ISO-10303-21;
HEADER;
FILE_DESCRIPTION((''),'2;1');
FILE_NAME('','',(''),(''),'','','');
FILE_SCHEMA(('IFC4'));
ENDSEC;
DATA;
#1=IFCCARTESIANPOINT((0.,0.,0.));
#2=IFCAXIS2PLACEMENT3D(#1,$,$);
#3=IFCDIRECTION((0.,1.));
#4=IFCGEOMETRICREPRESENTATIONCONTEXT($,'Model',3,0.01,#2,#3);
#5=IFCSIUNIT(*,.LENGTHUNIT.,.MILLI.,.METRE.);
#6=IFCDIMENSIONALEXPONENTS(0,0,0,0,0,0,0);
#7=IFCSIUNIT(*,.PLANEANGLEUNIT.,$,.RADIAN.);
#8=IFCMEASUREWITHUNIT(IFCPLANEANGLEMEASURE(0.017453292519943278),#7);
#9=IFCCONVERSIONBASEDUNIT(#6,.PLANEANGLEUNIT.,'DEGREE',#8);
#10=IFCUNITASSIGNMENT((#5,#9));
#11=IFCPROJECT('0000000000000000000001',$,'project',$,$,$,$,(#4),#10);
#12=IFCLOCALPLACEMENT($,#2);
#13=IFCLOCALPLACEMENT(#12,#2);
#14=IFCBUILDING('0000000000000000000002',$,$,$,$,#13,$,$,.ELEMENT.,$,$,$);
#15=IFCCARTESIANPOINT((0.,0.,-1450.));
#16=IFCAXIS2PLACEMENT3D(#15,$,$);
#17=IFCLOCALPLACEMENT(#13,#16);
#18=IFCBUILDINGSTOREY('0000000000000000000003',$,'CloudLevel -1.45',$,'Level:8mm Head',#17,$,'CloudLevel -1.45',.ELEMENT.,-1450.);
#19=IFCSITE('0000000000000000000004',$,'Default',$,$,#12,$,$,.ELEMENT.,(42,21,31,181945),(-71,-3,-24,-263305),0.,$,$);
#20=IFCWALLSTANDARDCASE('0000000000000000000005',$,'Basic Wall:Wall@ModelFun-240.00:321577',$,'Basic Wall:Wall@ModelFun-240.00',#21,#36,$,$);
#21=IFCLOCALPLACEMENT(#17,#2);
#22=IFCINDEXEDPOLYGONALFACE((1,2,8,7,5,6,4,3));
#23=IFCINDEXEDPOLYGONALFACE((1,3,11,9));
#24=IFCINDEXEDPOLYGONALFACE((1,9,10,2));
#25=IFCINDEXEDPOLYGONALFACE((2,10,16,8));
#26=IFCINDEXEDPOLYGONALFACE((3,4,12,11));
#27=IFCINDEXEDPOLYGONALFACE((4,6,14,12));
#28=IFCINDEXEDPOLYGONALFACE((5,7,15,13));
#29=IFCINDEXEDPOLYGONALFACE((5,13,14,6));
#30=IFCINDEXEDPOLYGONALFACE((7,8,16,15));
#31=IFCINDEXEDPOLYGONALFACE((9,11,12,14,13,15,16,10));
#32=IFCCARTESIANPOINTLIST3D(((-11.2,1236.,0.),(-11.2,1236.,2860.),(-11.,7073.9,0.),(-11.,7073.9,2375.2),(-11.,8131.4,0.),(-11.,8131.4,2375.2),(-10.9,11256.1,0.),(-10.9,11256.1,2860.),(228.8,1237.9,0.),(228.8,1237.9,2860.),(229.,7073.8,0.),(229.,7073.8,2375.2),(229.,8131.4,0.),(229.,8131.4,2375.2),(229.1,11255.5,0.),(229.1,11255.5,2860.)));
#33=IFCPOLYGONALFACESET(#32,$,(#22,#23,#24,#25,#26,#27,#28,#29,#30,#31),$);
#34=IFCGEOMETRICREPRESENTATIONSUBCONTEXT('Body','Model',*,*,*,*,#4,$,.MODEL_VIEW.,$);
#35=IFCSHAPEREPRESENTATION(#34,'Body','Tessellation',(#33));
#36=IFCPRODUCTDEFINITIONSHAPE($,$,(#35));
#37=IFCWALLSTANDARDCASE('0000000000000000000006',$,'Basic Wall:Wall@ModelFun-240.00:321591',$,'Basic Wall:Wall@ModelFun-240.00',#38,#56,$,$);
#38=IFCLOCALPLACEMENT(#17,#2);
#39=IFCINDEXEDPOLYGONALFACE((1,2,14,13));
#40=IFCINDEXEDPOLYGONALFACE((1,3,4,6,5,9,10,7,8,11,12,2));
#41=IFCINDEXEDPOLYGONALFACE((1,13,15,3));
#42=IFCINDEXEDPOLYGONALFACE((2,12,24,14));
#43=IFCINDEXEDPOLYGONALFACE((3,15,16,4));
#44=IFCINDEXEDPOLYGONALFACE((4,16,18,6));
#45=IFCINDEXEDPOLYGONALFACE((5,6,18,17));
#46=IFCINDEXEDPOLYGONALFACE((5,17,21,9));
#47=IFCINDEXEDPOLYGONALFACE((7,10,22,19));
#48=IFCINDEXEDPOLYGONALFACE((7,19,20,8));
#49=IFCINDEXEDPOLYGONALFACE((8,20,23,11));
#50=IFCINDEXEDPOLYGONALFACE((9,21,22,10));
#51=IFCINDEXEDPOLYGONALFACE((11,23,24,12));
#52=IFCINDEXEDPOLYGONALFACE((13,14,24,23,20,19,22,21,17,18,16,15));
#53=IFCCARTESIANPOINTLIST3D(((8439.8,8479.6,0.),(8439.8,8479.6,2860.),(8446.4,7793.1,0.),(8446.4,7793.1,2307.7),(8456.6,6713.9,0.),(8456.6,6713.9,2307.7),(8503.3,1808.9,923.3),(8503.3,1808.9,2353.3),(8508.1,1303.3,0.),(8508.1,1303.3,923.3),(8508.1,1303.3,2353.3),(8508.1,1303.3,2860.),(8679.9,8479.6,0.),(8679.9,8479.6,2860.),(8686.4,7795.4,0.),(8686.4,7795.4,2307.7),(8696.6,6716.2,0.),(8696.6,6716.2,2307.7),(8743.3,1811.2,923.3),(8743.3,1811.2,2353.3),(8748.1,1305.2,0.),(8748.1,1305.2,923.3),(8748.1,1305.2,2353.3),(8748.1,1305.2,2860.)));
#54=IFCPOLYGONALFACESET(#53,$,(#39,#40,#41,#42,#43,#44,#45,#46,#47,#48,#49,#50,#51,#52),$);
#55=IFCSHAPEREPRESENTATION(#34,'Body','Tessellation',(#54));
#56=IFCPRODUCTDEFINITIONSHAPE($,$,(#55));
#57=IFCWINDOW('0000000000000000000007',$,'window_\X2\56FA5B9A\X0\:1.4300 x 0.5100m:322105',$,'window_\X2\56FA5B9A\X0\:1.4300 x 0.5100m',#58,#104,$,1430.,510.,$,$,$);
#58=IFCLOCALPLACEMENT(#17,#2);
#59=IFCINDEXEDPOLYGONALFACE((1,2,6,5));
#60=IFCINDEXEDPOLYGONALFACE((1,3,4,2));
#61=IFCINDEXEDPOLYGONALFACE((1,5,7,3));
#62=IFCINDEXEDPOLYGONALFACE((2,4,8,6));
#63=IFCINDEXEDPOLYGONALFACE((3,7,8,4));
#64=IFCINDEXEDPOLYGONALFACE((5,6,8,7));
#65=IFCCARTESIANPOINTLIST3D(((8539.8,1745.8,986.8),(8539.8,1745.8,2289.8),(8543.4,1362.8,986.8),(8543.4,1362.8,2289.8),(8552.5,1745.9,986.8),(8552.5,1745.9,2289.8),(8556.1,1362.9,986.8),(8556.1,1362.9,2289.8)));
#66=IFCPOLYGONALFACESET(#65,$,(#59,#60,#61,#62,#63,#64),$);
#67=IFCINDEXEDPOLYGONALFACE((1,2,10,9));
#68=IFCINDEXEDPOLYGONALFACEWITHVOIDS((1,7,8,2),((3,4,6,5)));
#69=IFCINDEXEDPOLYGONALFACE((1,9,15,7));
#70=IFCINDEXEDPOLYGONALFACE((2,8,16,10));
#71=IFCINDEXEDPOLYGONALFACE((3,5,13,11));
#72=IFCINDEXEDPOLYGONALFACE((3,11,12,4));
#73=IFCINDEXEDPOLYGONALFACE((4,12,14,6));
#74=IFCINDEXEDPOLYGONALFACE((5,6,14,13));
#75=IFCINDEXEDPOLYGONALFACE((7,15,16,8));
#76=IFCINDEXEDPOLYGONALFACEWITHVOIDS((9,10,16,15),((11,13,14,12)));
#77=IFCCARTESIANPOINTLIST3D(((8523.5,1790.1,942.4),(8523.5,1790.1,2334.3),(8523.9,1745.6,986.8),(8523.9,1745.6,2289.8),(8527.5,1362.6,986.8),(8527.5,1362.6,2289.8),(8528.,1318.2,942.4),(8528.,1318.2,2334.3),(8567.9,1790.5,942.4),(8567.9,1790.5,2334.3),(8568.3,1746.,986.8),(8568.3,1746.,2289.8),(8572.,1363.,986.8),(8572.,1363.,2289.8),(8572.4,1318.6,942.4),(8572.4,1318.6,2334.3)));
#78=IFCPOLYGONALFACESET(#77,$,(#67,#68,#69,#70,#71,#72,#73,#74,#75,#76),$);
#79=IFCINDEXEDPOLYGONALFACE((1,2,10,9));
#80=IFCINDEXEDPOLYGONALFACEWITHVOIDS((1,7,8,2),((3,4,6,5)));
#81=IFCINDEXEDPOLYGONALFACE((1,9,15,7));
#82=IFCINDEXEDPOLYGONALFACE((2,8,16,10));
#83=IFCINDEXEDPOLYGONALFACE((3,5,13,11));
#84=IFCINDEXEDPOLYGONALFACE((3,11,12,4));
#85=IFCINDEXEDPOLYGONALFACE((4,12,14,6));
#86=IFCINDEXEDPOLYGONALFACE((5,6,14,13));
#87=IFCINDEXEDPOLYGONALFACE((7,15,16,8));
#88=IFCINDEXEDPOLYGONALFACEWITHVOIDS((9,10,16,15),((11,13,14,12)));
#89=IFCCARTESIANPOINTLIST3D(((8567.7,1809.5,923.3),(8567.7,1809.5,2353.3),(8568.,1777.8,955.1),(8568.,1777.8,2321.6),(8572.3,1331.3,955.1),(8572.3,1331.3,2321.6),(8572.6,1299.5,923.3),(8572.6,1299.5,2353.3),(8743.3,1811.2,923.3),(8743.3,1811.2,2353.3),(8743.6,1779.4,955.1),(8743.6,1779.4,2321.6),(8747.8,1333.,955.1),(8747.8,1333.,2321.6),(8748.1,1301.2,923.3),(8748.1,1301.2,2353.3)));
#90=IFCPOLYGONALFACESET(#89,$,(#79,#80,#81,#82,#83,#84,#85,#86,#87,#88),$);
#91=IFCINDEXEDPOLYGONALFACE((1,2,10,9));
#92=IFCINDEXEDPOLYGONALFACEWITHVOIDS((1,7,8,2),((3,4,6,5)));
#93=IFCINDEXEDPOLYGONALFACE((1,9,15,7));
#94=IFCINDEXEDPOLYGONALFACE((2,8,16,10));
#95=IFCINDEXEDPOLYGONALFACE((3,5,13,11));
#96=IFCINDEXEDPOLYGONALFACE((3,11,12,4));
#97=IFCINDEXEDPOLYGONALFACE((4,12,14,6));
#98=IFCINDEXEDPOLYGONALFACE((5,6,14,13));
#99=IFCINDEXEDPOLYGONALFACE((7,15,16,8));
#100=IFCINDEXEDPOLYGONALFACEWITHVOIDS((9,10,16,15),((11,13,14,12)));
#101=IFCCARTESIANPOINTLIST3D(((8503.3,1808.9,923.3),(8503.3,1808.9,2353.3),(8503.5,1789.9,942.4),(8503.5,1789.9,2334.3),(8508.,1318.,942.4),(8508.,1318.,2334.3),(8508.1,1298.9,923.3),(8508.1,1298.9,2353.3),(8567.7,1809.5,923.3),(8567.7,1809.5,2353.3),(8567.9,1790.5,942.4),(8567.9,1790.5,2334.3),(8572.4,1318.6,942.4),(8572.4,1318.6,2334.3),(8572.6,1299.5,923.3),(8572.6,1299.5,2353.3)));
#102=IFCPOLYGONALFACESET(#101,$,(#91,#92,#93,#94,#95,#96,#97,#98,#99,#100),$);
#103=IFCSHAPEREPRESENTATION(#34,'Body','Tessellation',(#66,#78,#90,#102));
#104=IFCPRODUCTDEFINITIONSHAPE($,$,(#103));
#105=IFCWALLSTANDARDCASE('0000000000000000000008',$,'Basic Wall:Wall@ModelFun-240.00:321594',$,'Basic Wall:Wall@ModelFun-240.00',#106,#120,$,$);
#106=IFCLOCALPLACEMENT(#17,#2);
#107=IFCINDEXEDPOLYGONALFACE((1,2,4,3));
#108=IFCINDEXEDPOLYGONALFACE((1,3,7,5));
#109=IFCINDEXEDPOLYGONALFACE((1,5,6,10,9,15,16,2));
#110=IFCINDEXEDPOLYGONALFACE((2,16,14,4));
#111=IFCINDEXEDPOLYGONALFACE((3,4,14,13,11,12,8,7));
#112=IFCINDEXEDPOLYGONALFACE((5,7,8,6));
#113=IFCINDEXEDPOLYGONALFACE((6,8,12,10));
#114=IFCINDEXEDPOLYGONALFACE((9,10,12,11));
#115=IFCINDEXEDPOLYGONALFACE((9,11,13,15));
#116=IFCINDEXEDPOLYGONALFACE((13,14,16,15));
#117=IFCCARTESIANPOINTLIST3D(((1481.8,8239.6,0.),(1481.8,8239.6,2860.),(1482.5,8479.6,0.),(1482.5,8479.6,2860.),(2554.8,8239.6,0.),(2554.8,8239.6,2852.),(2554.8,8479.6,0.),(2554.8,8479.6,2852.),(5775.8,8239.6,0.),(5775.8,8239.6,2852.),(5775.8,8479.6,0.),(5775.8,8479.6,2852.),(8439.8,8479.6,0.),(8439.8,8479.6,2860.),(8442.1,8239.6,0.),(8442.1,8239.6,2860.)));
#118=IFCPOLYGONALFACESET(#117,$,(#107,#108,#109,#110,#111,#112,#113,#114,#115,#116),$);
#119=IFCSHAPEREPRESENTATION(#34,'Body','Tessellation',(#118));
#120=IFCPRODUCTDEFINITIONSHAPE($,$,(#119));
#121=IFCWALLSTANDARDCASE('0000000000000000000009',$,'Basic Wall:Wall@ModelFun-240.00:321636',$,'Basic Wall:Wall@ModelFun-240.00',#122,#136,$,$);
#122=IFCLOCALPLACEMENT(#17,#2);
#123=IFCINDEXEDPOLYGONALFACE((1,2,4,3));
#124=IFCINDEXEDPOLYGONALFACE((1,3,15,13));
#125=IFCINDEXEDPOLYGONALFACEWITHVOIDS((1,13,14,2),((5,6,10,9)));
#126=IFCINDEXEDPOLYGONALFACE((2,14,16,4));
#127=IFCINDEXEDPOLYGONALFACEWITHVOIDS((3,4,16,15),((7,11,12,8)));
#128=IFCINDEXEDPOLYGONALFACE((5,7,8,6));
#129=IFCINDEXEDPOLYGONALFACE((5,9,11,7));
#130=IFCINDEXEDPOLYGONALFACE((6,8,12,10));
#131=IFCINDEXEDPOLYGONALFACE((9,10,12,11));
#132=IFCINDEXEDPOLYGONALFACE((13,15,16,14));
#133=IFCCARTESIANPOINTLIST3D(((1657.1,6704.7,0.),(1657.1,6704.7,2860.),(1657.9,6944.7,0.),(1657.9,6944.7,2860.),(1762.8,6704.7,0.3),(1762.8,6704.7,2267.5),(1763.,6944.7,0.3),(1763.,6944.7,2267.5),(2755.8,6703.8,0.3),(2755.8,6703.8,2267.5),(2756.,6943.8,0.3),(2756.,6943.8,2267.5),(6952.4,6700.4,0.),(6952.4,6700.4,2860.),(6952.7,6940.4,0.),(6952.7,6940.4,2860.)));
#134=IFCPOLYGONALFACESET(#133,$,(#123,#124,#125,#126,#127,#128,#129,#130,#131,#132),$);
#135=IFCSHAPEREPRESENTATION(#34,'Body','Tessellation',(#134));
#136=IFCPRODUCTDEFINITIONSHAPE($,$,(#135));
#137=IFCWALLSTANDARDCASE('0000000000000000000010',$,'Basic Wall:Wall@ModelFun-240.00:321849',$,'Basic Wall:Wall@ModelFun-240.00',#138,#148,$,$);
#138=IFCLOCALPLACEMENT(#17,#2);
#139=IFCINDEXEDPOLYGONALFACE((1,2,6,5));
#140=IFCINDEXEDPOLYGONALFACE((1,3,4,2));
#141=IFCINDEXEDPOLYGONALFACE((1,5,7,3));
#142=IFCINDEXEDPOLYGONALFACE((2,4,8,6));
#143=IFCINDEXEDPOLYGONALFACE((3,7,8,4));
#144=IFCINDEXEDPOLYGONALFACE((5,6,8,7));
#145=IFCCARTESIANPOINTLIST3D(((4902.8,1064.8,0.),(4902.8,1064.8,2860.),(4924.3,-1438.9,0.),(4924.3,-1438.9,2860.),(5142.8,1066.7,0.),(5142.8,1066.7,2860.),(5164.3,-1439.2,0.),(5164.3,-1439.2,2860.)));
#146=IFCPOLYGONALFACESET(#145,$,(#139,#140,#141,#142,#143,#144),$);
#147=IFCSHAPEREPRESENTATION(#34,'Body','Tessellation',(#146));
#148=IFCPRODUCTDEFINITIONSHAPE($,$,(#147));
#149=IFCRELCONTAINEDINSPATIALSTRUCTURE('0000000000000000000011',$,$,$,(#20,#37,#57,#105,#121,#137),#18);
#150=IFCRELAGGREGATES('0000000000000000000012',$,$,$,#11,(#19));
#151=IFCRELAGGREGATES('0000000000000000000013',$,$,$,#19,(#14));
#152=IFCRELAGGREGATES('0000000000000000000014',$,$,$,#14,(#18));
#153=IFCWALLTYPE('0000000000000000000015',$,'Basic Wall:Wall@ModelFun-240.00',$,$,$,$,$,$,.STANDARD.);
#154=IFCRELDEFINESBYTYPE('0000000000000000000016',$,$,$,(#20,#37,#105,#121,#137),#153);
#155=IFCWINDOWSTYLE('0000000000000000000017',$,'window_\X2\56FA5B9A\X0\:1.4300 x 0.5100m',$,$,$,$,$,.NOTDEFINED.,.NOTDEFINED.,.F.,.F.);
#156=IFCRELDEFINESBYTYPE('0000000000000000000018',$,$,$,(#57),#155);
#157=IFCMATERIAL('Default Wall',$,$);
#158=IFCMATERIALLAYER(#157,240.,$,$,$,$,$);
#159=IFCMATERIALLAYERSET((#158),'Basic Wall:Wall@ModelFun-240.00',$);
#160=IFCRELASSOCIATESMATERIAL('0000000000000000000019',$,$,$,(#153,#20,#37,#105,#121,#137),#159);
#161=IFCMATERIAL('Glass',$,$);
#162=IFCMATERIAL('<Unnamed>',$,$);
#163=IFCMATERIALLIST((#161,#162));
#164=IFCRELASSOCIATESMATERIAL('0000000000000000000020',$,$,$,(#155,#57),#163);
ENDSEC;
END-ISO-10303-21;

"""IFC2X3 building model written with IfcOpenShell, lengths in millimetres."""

from ifc_helpers import new_model, entity, si_unit, converted_unit, direction, frame, frame_2d, origin, place, context, subcontext, project, spatial, polyline, rectangle, outline, extrude, source, transform, mapped, material, material_list, layer, layer_set, layer_usage, type_object, type_shapes, element, fill, save


model = new_model("IFC2X3")

# Units and contexts
model_context = context("Model", 3, precision=0.01, world=origin(), true_north=direction((0.0, 1.0)))
body_context = subcontext(model_context, "Body", "Model", "MODEL_VIEW")
ifc_project = project(units=[si_unit("LENGTHUNIT", "METRE", prefix="MILLI"), converted_unit("PLANEANGLEUNIT", "DEGREE", entity("IfcPlaneAngleMeasure", 0.017453292519943278), si_unit("PLANEANGLEUNIT", "RADIAN"), dimensions=[0, 0, 0, 0, 0, 0, 0])], contexts=[model_context])

# Site, building, storey
site_placement = place(None, origin())
site = spatial("IfcSite", under=ifc_project, at=site_placement, Name="Default", CompositionType="ELEMENT", RefLatitude=(42, 21, 31, 181945), RefLongitude=(-71, -3, -24, -263305), RefElevation=0.0)
building_placement = place(site_placement, origin())
building = spatial("IfcBuilding", under=site, at=building_placement, CompositionType="ELEMENT")
storey_placement = place(building_placement, frame((0.0, 0.0, -1450.0)))
storey = spatial("IfcBuildingStorey", under=building, at=storey_placement, Name="CloudLevel -1.45", ObjectType="Level:8mm Head", LongName="CloudLevel -1.45", CompositionType="ELEMENT", Elevation=-1450.0)

# Shared definitions
ifc_material_1 = material(Name="Default Wall")
ifc_layer_1 = layer(ifc_material_1, 240.0)
ifc_layer_set_1 = layer_set([ifc_layer_1], Name="Basic Wall:Wall@ModelFun-240.00")
ifc_layer_usage_1 = layer_usage(ifc_layer_set_1, "AXIS2", "NEGATIVE", 120.0)
wall_type_1 = type_object("IfcWallType", Name="Basic Wall:Wall@ModelFun-240.00", PredefinedType="STANDARD", material=ifc_layer_set_1)
ifc_material_2 = material(Name="Glass")
ifc_material_3 = material(Name="<Unnamed>")
ifc_material_list = material_list([ifc_material_2, ifc_material_3])

# Wall, opening
wall_1_placement = place(storey_placement, frame((109.1, 11256.1, 0.0), z_axis=(0.0, 0.0, 1.0), x_axis=(-0.000035, -1.0, 0.0)))
wall_1 = element("IfcWallStandardCase", 1, at=wall_1_placement, inside=storey, type_object=wall_type_1, material=ifc_layer_usage_1, Name="Basic Wall:Wall@ModelFun-240.00:321577", ObjectType="Basic Wall:Wall@ModelFun-240.00", context=body_context, shape_type="SweptSolid", body=[
    extrude(outline(polyline([(0.0, -120.0), (2902.8, -120.0), (3022.8, -120.0), (4539.7, -120.0), (4739.7, -120.0), (8178.4, -120.0), (8418.4, -120.0), (10020.2, -120.0), (10018.3, 120.0), (3012.2, 120.0), (2772.2, 120.0), (0.6, 120.0), (0.0, -120.0)])), origin(), (0.0, 0.0, 1.0), 2860.0),
])
opening_1_placement = place(wall_1_placement, frame((3124.8, -120.0, 0.0)))
element("IfcOpeningElement", 2, at=opening_1_placement, cuts=wall_1, ObjectType="Opening", context=body_context, shape_type="SweptSolid", body=[
    extrude(rectangle(XDim=1057.5, YDim=2375.2, at=frame_2d((1187.6, 528.8), x_axis=(0.0, 1.0))), frame((0.0, 0.0, 0.0), z_axis=(0.0, 1.0, 0.0), x_axis=(0.0, 0.0, 1.0)), (0.0, 0.0, 1.0), 240.0),
])

# Wall, openings, window
wall_2_placement = place(storey_placement, frame((8559.8, 8480.7, 0.0), z_axis=(0.0, 0.0, 1.0), x_axis=(0.009512, -0.999955, 0.0)))
wall_2 = element("IfcWallStandardCase", 3, at=wall_2_placement, inside=storey, type_object=wall_type_1, material=ifc_layer_usage_1, Name="Basic Wall:Wall@ModelFun-240.00:321591", ObjectType="Basic Wall:Wall@ModelFun-240.00", context=body_context, shape_type="SweptSolid", body=[
    extrude(outline(polyline([(0.0, -120.0), (240.0, -120.0), (5749.5, -120.0), (5989.6, -120.0), (7176.6, -120.0), (7177.0, 120.0), (2.3, 120.0), (0.0, -120.0)])), origin(), (0.0, 0.0, 1.0), 2860.0),
])
opening_2_placement = place(wall_2_placement, frame((686.5, -120.0, -6.7)))
element("IfcOpeningElement", 4, at=opening_2_placement, cuts=wall_2, ObjectType="Opening", context=body_context, shape_type="SweptSolid", body=[
    extrude(rectangle(XDim=1079.2, YDim=2314.4, at=frame_2d((1157.2, 539.6), x_axis=(0.0, 1.0))), frame((0.0, 0.0, 0.0), z_axis=(0.0, 1.0, 0.0), x_axis=(0.0, 0.0, 1.0)), (0.0, 0.0, 1.0), 240.0),
])
opening_3_placement = place(wall_2_placement, frame((7181.0, 120.0, 923.3)))
opening_3 = element("IfcOpeningElement", 5, at=opening_3_placement, cuts=wall_2, ObjectType="Opening", context=body_context, shape_type="SweptSolid", body=[
    extrude(rectangle(XDim=1430.0, YDim=510.0, at=frame_2d((715.0, 255.0), x_axis=(-1.0, 0.0))), frame((0.0, 0.0, 0.0), z_axis=(0.0, -1.0, 0.0), x_axis=(0.0, 0.0, 1.0)), (0.0, 0.0, 1.0), 240.0),
])
window_style_1 = type_object("IfcWindowStyle", Name="window_固定:1.4300 x 0.5100m", ConstructionType="NOTDEFINED", OperationType="NOTDEFINED", ParameterTakesPrecedence=False, Sizeable=False, material=ifc_material_list)
shared_shape_1 = source(origin(), body_context, "Body", "SweptSolid", [
    extrude(rectangle(XDim=383.0, YDim=12.7, at=frame_2d((0.0, 0.0), x_axis=(1.0, 0.0))), frame((331.2, 197.8, 63.5)), (0.0, 0.0, 1.0), 1303.0),
    extrude(outline(polyline([(-235.9, -695.9), (235.9, -695.9), (235.9, 695.9), (-235.9, 695.9), (-235.9, -695.9)]), holes=[polyline([(-191.5, -651.5), (-191.5, 651.5), (191.5, 651.5), (191.5, -651.5), (-191.5, -651.5)])]), frame((331.2, 220.0, 715.0), z_axis=(0.0, -1.0, 0.0), x_axis=(-1.0, 0.0, 0.0)), (0.0, 0.0, 1.0), 44.4),
    extrude(outline(polyline([(-255.0, -715.0), (255.0, -715.0), (255.0, 715.0), (-255.0, 715.0), (-255.0, -715.0)]), holes=[polyline([(-223.2, -683.2), (-223.2, 683.2), (223.2, 683.2), (223.2, -683.2), (-223.2, -683.2)])]), frame((331.2, 175.5, 715.0), z_axis=(0.0, -1.0, 0.0), x_axis=(-1.0, 0.0, 0.0)), (0.0, 0.0, 1.0), 175.5),
    extrude(outline(polyline([(-715.0, -255.0), (715.0, -255.0), (715.0, 255.0), (-715.0, 255.0), (-715.0, -255.0)]), holes=[polyline([(-695.9, -235.9), (-695.9, 235.9), (695.9, 235.9), (695.9, -235.9), (-695.9, -235.9)])]), frame((331.2, 240.0, 715.0), z_axis=(0.0, -1.0, 0.0), x_axis=(0.0, 0.0, -1.0)), (0.0, 0.0, 1.0), 64.4),
])
type_shapes(window_style_1, [shared_shape_1])
window_1_placement = place(opening_3_placement, frame((76.2, 0.0, 0.0), z_axis=(0.0, 0.0, 1.0), x_axis=(-1.0, 0.0, 0.0)))
window_1 = element("IfcWindow", 6, at=window_1_placement, inside=storey, type_object=window_style_1, material=ifc_material_list, Name="window_固定:1.4300 x 0.5100m:322105", ObjectType="window_固定:1.4300 x 0.5100m", OverallHeight=1430.0, OverallWidth=510.0, context=body_context, shape_type="MappedRepresentation", body=[
    mapped(shared_shape_1, transform((0.0, 0.0, 0.0), scale=1.0)),
])
fill(opening_3, window_1)

# Wall, opening
wall_3_placement = place(storey_placement, frame((8442.1, 8359.6, 0.0), z_axis=(0.0, 0.0, 1.0), x_axis=(-1.0, 0.0, 0.0)))
wall_3 = element("IfcWallStandardCase", 7, at=wall_3_placement, inside=storey, type_object=wall_type_1, material=ifc_layer_usage_1, Name="Basic Wall:Wall@ModelFun-240.00:321594", ObjectType="Basic Wall:Wall@ModelFun-240.00", context=body_context, shape_type="SweptSolid", body=[
    extrude(outline(polyline([(2.3, -120.0), (6871.1, -120.0), (6959.6, -120.0), (6960.3, 101.5), (6960.4, 120.0), (6780.4, 120.0), (0.0, 120.0), (2.3, -120.0)])), origin(), (0.0, 0.0, 1.0), 2860.0),
])
opening_4_placement = place(wall_3_placement, frame((2666.3, -120.0, 0.0)))
element("IfcOpeningElement", 8, at=opening_4_placement, cuts=wall_3, ObjectType="Opening", context=body_context, shape_type="SweptSolid", body=[
    extrude(rectangle(XDim=2852.0, YDim=3221.0, at=frame_2d((1426.0, 1610.5), x_axis=(1.0, 0.0))), frame((0.0, 0.0, 0.0), z_axis=(0.0, 1.0, 0.0), x_axis=(0.0, 0.0, 1.0)), (0.0, 0.0, 1.0), 240.0),
])

# Wall, opening
wall_4_placement = place(storey_placement, frame((1657.2, 6824.7, 0.0), z_axis=(0.0, 0.0, 1.0), x_axis=(1.0, -0.000828, 0.0)))
wall_4 = element("IfcWallStandardCase", 9, at=wall_4_placement, inside=storey, type_object=wall_type_1, material=ifc_layer_usage_1, Name="Basic Wall:Wall@ModelFun-240.00:321636", ObjectType="Basic Wall:Wall@ModelFun-240.00", context=body_context, shape_type="SweptSolid", body=[
    extrude(outline(polyline([(5295.2, -120.0), (5295.4, 120.0), (0.5, 120.0), (0.0, -120.0), (5295.2, -120.0)])), origin(), (0.0, 0.0, 1.0), 2860.0),
])
opening_5_placement = place(wall_4_placement, frame((105.6, -120.0, 0.3)))
element("IfcOpeningElement", 10, at=opening_5_placement, cuts=wall_4, ObjectType="Opening", context=body_context, shape_type="SweptSolid", body=[
    extrude(rectangle(XDim=993.0, YDim=2267.2, at=frame_2d((1133.6, 496.5), x_axis=(0.0, 1.0))), frame((0.0, 0.0, 0.0), z_axis=(0.0, 1.0, 0.0), x_axis=(0.0, 0.0, 1.0)), (0.0, 0.0, 1.0), 240.0),
])

# Wall
wall_5_placement = place(storey_placement, frame((5022.8, 1065.8, 0.0), z_axis=(0.0, 0.0, 1.0), x_axis=(0.008574, -0.999963, 0.0)))
element("IfcWallStandardCase", 11, at=wall_5_placement, inside=storey, type_object=wall_type_1, material=ifc_layer_usage_1, Name="Basic Wall:Wall@ModelFun-240.00:321849", ObjectType="Basic Wall:Wall@ModelFun-240.00", context=body_context, shape_type="SweptSolid", body=[
    extrude(outline(polyline([(2503.8, -120.0), (2506.1, 120.0), (0.2, 120.0), (0.0, -120.0), (2503.8, -120.0)])), origin(), (0.0, 0.0, 1.0), 2860.0),
])

save(model, "model.ifc")
